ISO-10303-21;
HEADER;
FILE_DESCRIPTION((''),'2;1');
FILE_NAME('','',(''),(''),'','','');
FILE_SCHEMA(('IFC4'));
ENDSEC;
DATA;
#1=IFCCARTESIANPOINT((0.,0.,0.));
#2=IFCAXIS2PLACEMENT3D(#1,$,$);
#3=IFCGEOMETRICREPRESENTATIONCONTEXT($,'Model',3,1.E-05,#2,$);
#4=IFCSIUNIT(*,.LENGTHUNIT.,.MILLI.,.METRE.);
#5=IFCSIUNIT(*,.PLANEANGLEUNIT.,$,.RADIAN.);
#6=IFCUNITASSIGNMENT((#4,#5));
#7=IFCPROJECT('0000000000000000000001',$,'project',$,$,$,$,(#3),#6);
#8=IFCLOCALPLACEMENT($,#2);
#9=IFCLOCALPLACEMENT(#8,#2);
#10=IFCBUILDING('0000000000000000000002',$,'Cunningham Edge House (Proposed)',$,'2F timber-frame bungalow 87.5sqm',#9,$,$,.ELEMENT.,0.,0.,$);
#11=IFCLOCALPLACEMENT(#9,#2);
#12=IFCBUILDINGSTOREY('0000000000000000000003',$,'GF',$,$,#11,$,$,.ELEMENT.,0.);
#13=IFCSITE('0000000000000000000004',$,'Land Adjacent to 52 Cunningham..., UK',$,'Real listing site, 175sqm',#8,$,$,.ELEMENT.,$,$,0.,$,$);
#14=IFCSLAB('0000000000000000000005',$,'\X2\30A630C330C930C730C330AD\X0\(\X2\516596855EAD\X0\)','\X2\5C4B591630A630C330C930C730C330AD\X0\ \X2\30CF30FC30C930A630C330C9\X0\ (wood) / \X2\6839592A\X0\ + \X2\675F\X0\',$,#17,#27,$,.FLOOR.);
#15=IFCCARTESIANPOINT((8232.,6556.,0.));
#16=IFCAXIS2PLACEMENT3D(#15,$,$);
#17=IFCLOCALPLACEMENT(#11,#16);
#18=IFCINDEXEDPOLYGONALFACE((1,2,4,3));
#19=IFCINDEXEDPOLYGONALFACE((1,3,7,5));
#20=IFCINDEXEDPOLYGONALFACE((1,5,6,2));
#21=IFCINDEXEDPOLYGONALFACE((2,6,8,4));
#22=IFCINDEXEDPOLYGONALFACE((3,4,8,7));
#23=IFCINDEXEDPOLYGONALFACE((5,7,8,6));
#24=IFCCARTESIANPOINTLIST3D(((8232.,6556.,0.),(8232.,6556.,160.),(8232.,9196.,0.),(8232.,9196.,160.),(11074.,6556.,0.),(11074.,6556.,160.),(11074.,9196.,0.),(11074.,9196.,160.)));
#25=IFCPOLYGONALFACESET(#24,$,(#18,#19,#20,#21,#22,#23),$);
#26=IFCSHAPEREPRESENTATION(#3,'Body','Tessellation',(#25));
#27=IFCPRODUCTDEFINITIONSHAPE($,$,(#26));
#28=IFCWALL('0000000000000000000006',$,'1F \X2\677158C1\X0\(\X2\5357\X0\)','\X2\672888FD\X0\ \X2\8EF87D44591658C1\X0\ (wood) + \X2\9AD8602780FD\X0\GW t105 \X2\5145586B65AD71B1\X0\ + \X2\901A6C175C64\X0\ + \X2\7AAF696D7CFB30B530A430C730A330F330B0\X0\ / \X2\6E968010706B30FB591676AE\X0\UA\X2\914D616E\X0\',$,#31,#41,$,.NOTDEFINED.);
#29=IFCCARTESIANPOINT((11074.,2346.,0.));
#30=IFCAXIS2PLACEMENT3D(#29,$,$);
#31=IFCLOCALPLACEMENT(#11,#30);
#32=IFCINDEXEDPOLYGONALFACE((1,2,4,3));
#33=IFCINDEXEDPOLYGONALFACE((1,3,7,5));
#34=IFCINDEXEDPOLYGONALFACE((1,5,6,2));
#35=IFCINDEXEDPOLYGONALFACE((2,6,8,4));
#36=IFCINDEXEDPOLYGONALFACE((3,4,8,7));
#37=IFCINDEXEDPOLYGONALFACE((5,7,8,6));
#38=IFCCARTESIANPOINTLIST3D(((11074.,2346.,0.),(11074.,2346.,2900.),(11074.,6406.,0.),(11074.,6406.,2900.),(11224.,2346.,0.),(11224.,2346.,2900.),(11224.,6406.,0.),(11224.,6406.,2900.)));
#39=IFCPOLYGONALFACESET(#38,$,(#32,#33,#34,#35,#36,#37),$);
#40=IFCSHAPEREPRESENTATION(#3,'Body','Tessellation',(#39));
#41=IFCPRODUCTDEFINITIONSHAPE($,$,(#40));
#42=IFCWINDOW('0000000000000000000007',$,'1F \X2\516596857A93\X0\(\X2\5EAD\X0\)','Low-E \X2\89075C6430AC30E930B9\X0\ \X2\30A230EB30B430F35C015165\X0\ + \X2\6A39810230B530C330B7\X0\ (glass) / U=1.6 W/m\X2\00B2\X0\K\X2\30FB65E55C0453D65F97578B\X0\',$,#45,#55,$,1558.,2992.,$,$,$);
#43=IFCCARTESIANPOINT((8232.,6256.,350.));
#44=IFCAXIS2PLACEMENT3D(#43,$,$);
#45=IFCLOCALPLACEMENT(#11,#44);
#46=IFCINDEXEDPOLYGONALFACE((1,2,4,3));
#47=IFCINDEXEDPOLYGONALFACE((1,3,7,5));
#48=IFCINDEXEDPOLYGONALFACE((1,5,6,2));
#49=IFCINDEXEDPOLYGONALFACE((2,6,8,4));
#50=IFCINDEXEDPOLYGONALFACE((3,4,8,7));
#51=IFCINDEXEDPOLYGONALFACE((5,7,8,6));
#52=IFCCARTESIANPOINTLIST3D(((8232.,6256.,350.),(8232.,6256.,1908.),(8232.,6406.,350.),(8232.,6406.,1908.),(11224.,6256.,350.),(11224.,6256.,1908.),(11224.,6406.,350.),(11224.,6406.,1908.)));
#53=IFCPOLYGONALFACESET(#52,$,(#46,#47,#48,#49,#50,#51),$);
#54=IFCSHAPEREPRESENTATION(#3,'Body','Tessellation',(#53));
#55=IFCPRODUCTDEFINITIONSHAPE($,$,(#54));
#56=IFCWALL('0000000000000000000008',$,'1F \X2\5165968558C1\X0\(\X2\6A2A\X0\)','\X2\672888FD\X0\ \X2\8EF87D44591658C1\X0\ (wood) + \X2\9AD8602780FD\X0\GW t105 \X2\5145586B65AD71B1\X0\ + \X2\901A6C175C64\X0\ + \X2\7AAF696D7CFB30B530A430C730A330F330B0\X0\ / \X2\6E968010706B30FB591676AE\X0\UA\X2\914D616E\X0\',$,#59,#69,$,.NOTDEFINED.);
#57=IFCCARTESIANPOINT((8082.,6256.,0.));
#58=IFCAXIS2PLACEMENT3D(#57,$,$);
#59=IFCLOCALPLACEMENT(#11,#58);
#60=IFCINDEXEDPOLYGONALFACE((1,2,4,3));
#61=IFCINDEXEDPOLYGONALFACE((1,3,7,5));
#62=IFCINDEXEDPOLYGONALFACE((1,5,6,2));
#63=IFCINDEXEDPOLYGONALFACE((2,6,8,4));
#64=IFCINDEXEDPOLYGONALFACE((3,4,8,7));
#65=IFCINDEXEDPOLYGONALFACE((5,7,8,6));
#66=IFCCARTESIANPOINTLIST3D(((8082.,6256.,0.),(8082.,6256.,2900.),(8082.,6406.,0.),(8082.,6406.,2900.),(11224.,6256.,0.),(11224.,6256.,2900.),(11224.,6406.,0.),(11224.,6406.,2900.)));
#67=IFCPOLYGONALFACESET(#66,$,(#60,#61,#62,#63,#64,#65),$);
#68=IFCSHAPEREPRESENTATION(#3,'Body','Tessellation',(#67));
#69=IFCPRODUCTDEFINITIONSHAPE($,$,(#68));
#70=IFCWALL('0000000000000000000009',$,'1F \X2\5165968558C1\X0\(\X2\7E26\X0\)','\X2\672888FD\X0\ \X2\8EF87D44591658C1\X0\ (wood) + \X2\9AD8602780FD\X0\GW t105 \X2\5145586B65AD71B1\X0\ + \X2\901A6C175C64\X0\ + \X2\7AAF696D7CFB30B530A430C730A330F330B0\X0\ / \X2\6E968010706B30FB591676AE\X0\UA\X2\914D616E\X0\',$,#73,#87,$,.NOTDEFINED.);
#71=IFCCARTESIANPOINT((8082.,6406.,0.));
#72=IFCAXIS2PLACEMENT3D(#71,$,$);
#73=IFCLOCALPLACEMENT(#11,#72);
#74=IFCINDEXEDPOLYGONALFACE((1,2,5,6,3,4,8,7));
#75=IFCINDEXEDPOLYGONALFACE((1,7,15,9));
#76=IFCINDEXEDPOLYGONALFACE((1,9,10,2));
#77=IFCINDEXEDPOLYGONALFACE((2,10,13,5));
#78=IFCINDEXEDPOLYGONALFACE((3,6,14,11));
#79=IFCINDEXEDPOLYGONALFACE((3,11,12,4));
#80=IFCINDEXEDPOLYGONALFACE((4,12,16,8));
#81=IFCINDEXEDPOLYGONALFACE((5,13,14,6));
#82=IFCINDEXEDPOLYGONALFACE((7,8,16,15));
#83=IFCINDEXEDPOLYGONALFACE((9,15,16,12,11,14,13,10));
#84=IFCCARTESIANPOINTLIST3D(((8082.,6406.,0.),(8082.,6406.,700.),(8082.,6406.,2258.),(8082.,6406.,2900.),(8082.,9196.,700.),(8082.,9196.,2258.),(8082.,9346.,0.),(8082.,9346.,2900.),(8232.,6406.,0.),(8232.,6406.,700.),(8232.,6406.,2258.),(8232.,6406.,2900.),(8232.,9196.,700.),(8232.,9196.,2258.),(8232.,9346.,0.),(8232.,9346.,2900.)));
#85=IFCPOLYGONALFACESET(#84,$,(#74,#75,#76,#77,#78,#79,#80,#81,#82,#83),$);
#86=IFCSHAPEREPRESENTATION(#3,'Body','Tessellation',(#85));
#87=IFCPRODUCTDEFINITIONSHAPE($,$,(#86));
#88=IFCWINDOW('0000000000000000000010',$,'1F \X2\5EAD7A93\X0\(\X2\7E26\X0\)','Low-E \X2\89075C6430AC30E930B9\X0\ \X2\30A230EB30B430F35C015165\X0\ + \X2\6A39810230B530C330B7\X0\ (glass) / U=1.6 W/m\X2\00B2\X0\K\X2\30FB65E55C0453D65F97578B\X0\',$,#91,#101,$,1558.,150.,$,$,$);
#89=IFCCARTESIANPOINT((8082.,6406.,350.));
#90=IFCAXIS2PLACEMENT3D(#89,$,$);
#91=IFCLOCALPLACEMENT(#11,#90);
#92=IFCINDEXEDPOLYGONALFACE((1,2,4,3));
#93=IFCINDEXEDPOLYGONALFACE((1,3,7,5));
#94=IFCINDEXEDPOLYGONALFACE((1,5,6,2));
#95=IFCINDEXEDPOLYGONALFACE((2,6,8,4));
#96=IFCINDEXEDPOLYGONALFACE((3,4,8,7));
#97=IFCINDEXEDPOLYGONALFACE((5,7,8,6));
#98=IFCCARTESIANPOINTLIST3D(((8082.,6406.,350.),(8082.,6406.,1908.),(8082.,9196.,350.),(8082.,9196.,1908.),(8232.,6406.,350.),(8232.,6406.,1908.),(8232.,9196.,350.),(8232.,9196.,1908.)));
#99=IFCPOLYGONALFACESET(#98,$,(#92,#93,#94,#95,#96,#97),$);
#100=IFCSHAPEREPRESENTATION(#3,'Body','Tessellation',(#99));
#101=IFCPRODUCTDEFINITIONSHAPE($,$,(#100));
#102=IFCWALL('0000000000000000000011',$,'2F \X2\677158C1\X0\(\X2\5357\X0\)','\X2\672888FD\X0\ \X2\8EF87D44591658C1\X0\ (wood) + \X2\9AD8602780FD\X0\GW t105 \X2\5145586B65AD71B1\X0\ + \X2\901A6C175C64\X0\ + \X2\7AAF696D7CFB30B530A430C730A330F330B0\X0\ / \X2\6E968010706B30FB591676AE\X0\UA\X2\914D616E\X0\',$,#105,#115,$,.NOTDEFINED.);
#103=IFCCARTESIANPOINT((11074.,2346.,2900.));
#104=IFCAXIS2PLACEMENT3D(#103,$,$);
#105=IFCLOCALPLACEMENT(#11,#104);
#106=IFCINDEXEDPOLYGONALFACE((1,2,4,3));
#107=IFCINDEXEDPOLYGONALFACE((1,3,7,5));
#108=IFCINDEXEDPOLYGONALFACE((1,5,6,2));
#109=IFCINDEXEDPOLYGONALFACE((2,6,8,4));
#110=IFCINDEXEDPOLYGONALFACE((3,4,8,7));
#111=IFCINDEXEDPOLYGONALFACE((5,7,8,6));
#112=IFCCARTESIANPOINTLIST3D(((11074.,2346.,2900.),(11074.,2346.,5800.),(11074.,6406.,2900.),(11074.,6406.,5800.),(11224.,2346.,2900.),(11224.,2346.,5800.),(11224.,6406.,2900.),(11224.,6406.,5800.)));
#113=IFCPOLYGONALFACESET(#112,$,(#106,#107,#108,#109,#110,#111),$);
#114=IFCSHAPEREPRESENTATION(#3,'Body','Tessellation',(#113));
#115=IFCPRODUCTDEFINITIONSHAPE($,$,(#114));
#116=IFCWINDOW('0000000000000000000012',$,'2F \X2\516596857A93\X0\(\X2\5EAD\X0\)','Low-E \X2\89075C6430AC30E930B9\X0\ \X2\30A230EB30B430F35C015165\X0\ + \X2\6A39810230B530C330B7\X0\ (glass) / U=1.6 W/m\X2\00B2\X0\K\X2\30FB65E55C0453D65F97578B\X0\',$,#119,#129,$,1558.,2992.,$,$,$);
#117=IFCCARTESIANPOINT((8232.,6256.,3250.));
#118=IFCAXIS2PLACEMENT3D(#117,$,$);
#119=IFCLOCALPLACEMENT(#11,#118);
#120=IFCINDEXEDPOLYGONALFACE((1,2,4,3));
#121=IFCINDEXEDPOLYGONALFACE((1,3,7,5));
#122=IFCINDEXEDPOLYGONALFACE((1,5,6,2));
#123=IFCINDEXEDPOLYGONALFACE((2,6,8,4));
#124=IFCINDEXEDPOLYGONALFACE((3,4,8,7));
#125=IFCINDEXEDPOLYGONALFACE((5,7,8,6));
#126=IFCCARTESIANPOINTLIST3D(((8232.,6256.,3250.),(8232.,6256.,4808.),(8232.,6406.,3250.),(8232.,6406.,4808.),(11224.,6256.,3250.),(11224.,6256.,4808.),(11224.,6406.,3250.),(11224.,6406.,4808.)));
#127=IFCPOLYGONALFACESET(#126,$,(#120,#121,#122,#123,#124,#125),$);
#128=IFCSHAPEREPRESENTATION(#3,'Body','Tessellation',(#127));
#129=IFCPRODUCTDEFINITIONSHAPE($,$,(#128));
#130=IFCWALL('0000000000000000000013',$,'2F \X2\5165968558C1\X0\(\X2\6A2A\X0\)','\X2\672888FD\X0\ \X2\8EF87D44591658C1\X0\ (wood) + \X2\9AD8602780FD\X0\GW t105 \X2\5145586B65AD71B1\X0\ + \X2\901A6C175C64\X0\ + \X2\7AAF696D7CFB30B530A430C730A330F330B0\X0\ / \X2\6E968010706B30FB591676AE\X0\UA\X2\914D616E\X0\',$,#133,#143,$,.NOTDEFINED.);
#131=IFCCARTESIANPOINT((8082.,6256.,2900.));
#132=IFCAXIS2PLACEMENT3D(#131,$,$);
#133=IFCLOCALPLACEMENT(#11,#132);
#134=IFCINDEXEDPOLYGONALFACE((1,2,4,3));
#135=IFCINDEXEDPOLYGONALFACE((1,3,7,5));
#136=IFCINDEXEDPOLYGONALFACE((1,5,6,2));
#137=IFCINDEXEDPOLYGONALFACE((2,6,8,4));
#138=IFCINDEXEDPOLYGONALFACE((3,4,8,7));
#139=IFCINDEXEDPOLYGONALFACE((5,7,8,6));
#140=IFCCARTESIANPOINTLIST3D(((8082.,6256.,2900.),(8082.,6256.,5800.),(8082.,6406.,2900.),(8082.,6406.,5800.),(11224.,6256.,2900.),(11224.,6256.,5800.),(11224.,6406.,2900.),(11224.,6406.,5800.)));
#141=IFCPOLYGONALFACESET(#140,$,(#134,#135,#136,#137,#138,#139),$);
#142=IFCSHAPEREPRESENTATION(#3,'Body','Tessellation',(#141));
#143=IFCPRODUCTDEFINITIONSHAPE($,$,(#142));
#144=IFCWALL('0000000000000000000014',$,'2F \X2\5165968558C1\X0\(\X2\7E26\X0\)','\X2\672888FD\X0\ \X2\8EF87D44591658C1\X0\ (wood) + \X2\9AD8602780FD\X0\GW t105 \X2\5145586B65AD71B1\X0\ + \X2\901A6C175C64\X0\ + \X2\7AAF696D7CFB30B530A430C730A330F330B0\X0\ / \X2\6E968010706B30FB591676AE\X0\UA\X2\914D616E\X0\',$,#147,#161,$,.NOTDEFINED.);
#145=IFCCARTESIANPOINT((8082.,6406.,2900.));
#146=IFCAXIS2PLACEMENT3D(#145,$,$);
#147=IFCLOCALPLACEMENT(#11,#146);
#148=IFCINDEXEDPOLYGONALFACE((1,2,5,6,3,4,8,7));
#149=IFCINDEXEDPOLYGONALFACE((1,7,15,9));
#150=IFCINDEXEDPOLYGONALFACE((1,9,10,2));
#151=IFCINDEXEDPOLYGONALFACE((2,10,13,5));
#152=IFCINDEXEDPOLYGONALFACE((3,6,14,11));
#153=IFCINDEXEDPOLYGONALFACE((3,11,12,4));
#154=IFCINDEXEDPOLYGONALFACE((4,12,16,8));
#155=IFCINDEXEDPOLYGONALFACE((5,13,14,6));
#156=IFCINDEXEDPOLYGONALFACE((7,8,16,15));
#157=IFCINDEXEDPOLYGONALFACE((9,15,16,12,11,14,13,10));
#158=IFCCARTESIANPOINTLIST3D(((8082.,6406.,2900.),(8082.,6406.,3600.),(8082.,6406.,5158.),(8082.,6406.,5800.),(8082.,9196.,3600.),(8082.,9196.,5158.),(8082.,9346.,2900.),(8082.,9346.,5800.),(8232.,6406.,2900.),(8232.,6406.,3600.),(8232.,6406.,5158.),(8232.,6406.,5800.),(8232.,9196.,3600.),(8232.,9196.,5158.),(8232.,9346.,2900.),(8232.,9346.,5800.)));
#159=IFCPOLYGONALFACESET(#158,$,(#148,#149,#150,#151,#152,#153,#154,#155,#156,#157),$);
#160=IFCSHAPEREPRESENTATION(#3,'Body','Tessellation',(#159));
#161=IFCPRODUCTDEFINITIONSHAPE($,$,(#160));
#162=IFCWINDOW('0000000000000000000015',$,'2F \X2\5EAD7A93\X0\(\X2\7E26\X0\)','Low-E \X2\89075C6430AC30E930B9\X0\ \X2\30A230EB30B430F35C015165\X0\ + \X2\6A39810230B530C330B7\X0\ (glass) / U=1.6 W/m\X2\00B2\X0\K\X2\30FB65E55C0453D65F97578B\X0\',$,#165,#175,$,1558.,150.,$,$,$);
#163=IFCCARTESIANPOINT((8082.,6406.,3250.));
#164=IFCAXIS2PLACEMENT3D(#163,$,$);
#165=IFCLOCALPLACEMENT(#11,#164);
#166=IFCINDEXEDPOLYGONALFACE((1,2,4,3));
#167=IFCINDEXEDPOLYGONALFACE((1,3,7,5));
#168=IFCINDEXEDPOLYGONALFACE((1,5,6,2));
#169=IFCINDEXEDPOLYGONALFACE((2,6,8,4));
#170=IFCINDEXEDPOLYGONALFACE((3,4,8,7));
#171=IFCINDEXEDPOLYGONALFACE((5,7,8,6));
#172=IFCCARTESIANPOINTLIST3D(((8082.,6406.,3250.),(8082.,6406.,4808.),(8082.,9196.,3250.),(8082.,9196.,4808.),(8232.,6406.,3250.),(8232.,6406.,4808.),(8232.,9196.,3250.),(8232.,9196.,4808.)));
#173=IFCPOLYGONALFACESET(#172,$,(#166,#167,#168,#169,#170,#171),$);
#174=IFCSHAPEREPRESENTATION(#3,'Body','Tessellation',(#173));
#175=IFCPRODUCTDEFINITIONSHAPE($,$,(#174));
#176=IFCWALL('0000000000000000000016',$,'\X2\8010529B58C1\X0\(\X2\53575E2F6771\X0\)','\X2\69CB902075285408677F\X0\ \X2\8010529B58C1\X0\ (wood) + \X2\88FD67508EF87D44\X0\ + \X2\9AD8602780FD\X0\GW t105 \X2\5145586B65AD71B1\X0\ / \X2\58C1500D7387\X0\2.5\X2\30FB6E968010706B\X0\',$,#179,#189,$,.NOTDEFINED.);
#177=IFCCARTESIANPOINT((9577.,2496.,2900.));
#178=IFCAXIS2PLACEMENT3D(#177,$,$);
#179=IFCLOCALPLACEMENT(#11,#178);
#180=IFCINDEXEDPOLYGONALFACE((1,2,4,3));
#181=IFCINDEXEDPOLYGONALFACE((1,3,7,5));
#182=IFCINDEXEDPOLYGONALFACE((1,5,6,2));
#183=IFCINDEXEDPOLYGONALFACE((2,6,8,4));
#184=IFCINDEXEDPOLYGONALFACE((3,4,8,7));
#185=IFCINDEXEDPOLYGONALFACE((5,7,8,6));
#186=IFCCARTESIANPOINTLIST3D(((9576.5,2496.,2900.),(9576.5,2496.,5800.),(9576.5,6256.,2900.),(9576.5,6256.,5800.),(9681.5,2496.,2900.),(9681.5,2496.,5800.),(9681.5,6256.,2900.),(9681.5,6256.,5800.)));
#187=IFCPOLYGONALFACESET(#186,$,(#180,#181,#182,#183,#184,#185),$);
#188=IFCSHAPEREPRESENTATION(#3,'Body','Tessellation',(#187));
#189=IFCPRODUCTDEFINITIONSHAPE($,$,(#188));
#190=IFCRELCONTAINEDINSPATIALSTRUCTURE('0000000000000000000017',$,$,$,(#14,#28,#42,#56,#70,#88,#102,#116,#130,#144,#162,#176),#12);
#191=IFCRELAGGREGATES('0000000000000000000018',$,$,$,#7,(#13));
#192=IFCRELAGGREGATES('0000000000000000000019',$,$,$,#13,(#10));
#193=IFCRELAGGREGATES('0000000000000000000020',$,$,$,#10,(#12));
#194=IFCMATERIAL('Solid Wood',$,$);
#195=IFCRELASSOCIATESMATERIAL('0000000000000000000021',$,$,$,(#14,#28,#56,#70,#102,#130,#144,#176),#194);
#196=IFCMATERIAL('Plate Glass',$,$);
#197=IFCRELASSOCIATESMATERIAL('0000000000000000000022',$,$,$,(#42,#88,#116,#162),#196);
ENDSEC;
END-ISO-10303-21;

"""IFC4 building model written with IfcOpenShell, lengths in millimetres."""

from ifc_helpers import new_model, si_unit, frame, frame_2d, origin, place, context, project, spatial, rectangle, extrude, material, element, fill, save


model = new_model("IFC4")

# Units and contexts
model_context = context("Model", 3, precision=1e-05, world=origin())
ifc_project = project(units=[si_unit("LENGTHUNIT", "METRE", prefix="MILLI"), si_unit("PLANEANGLEUNIT", "RADIAN")], contexts=[model_context])

# Site, building, storey
site_placement = place(None, origin())
site = spatial("IfcSite", under=ifc_project, at=site_placement, Name="Land Adjacent to 52 Cunningham..., UK", ObjectType="Real listing site, 175sqm", CompositionType="ELEMENT", RefElevation=0.0)
building_placement = place(site_placement, origin())
building = spatial("IfcBuilding", under=site, at=building_placement, Name="Cunningham Edge House (Proposed)", ObjectType="2F timber-frame bungalow 87.5sqm", CompositionType="ELEMENT", ElevationOfRefHeight=0.0, ElevationOfTerrain=0.0)
storey_placement = place(building_placement, origin())
storey = spatial("IfcBuildingStorey", under=building, at=storey_placement, Name="GF", CompositionType="ELEMENT", Elevation=0.0)

# Slab
ifc_material_1 = material(Name="Solid Wood")
slab_placement = place(storey_placement, frame((8232.0, 6556.0, 0.0)))
element("IfcSlab", 1, at=slab_placement, inside=storey, material=ifc_material_1, Name="ウッドデッキ(入隅庭)", Description="屋外ウッドデッキ ハードウッド (wood) / 根太 + 束", PredefinedType="FLOOR", context=model_context, shape_type="SweptSolid", body=[
    extrude(rectangle(XDim=2842.0, YDim=2640.0, at=frame_2d((1421.0, 1320.0))), frame((8232.0, 6556.0, 0.0)), (0.0, 0.0, 1.0), 160.0),
])

# Wall, opening, window
wall_1_placement = place(storey_placement, frame((11074.0, 2346.0, 0.0)))
wall_1 = element("IfcWall", 2, at=wall_1_placement, inside=storey, material=ifc_material_1, Name="1F 東壁(南)", Description="木製 軸組外壁 (wood) + 高性能GW t105 充填断熱 + 通気層 + 窯業系サイディング / 準耐火・外皮UA配慮", PredefinedType="NOTDEFINED", context=model_context, shape_type="SweptSolid", body=[
    extrude(rectangle(XDim=150.0, YDim=4060.0, at=frame_2d((75.0, 2030.0))), frame((11074.0, 2346.0, 0.0)), (0.0, 0.0, 1.0), 2900.0),
])
opening_1_placement = place(storey_placement, frame((8232.0, 6256.0, 350.0)))
opening_1 = element("IfcOpeningElement", 3, at=opening_1_placement, cuts=wall_1, PredefinedType="NOTDEFINED", context=model_context, shape_type="SweptSolid", body=[
    extrude(rectangle(XDim=2992.0, YDim=150.0, at=frame_2d((1496.0, 75.0))), frame((8232.0, 6256.0, 350.0)), (0.0, 0.0, 1.0), 1558.0),
])
ifc_material_2 = material(Name="Plate Glass")
window_1_placement = place(storey_placement, frame((8232.0, 6256.0, 350.0)))
window_1 = element("IfcWindow", 4, at=window_1_placement, inside=storey, material=ifc_material_2, Name="1F 入隅窓(庭)", Description="Low-E 複層ガラス アルゴン封入 + 樹脂サッシ (glass) / U=1.6 W/m²K・日射取得型", OverallHeight=1558.0, OverallWidth=2992.0, context=model_context, shape_type="SweptSolid", body=[
    extrude(rectangle(XDim=2992.0, YDim=150.0, at=frame_2d((1496.0, 75.0))), frame((8232.0, 6256.0, 350.0)), (0.0, 0.0, 1.0), 1558.0),
])
fill(opening_1, window_1)

# Wall
wall_2_placement = place(storey_placement, frame((8082.0, 6256.0, 0.0)))
element("IfcWall", 5, at=wall_2_placement, inside=storey, material=ifc_material_1, Name="1F 入隅壁(横)", Description="木製 軸組外壁 (wood) + 高性能GW t105 充填断熱 + 通気層 + 窯業系サイディング / 準耐火・外皮UA配慮", PredefinedType="NOTDEFINED", context=model_context, shape_type="SweptSolid", body=[
    extrude(rectangle(XDim=3142.0, YDim=150.0, at=frame_2d((1571.0, 75.0))), frame((8082.0, 6256.0, 0.0)), (0.0, 0.0, 1.0), 2900.0),
])

# Wall, opening, window
wall_3_placement = place(storey_placement, frame((8082.0, 6406.0, 0.0)))
wall_3 = element("IfcWall", 6, at=wall_3_placement, inside=storey, material=ifc_material_1, Name="1F 入隅壁(縦)", Description="木製 軸組外壁 (wood) + 高性能GW t105 充填断熱 + 通気層 + 窯業系サイディング / 準耐火・外皮UA配慮", PredefinedType="NOTDEFINED", context=model_context, shape_type="SweptSolid", body=[
    extrude(rectangle(XDim=150.0, YDim=2940.0, at=frame_2d((75.0, 1470.0))), frame((8082.0, 6406.0, 0.0)), (0.0, 0.0, 1.0), 2900.0),
])
opening_2_placement = place(storey_placement, frame((8082.0, 6406.0, 350.0)))
opening_2 = element("IfcOpeningElement", 7, at=opening_2_placement, cuts=wall_3, PredefinedType="NOTDEFINED", context=model_context, shape_type="SweptSolid", body=[
    extrude(rectangle(XDim=150.0, YDim=2790.0, at=frame_2d((75.0, 1395.0))), frame((8082.0, 6406.0, 350.0)), (0.0, 0.0, 1.0), 1558.0),
])
window_2_placement = place(storey_placement, frame((8082.0, 6406.0, 350.0)))
window_2 = element("IfcWindow", 8, at=window_2_placement, inside=storey, material=ifc_material_2, Name="1F 庭窓(縦)", Description="Low-E 複層ガラス アルゴン封入 + 樹脂サッシ (glass) / U=1.6 W/m²K・日射取得型", OverallHeight=1558.0, OverallWidth=150.0, context=model_context, shape_type="SweptSolid", body=[
    extrude(rectangle(XDim=150.0, YDim=2790.0, at=frame_2d((75.0, 1395.0))), frame((8082.0, 6406.0, 350.0)), (0.0, 0.0, 1.0), 1558.0),
])
fill(opening_2, window_2)

# Wall, opening, window
wall_4_placement = place(storey_placement, frame((11074.0, 2346.0, 2900.0)))
wall_4 = element("IfcWall", 9, at=wall_4_placement, inside=storey, material=ifc_material_1, Name="2F 東壁(南)", Description="木製 軸組外壁 (wood) + 高性能GW t105 充填断熱 + 通気層 + 窯業系サイディング / 準耐火・外皮UA配慮", PredefinedType="NOTDEFINED", context=model_context, shape_type="SweptSolid", body=[
    extrude(rectangle(XDim=150.0, YDim=4060.0, at=frame_2d((75.0, 2030.0))), frame((11074.0, 2346.0, 2900.0)), (0.0, 0.0, 1.0), 2900.0),
])
opening_3_placement = place(storey_placement, frame((8232.0, 6256.0, 3250.0)))
opening_3 = element("IfcOpeningElement", 10, at=opening_3_placement, cuts=wall_4, PredefinedType="NOTDEFINED", context=model_context, shape_type="SweptSolid", body=[
    extrude(rectangle(XDim=2992.0, YDim=150.0, at=frame_2d((1496.0, 75.0))), frame((8232.0, 6256.0, 3250.0)), (0.0, 0.0, 1.0), 1558.0),
])
window_3_placement = place(storey_placement, frame((8232.0, 6256.0, 3250.0)))
window_3 = element("IfcWindow", 11, at=window_3_placement, inside=storey, material=ifc_material_2, Name="2F 入隅窓(庭)", Description="Low-E 複層ガラス アルゴン封入 + 樹脂サッシ (glass) / U=1.6 W/m²K・日射取得型", OverallHeight=1558.0, OverallWidth=2992.0, context=model_context, shape_type="SweptSolid", body=[
    extrude(rectangle(XDim=2992.0, YDim=150.0, at=frame_2d((1496.0, 75.0))), frame((8232.0, 6256.0, 3250.0)), (0.0, 0.0, 1.0), 1558.0),
])
fill(opening_3, window_3)

# Wall
wall_5_placement = place(storey_placement, frame((8082.0, 6256.0, 2900.0)))
element("IfcWall", 12, at=wall_5_placement, inside=storey, material=ifc_material_1, Name="2F 入隅壁(横)", Description="木製 軸組外壁 (wood) + 高性能GW t105 充填断熱 + 通気層 + 窯業系サイディング / 準耐火・外皮UA配慮", PredefinedType="NOTDEFINED", context=model_context, shape_type="SweptSolid", body=[
    extrude(rectangle(XDim=3142.0, YDim=150.0, at=frame_2d((1571.0, 75.0))), frame((8082.0, 6256.0, 2900.0)), (0.0, 0.0, 1.0), 2900.0),
])

# Wall, opening, window
wall_6_placement = place(storey_placement, frame((8082.0, 6406.0, 2900.0)))
wall_6 = element("IfcWall", 13, at=wall_6_placement, inside=storey, material=ifc_material_1, Name="2F 入隅壁(縦)", Description="木製 軸組外壁 (wood) + 高性能GW t105 充填断熱 + 通気層 + 窯業系サイディング / 準耐火・外皮UA配慮", PredefinedType="NOTDEFINED", context=model_context, shape_type="SweptSolid", body=[
    extrude(rectangle(XDim=150.0, YDim=2940.0, at=frame_2d((75.0, 1470.0))), frame((8082.0, 6406.0, 2900.0)), (0.0, 0.0, 1.0), 2900.0),
])
opening_4_placement = place(storey_placement, frame((8082.0, 6406.0, 3250.0)))
opening_4 = element("IfcOpeningElement", 14, at=opening_4_placement, cuts=wall_6, PredefinedType="NOTDEFINED", context=model_context, shape_type="SweptSolid", body=[
    extrude(rectangle(XDim=150.0, YDim=2790.0, at=frame_2d((75.0, 1395.0))), frame((8082.0, 6406.0, 3250.0)), (0.0, 0.0, 1.0), 1558.0),
])
window_4_placement = place(storey_placement, frame((8082.0, 6406.0, 3250.0)))
window_4 = element("IfcWindow", 15, at=window_4_placement, inside=storey, material=ifc_material_2, Name="2F 庭窓(縦)", Description="Low-E 複層ガラス アルゴン封入 + 樹脂サッシ (glass) / U=1.6 W/m²K・日射取得型", OverallHeight=1558.0, OverallWidth=150.0, context=model_context, shape_type="SweptSolid", body=[
    extrude(rectangle(XDim=150.0, YDim=2790.0, at=frame_2d((75.0, 1395.0))), frame((8082.0, 6406.0, 3250.0)), (0.0, 0.0, 1.0), 1558.0),
])
fill(opening_4, window_4)

# Wall
wall_7_placement = place(storey_placement, frame((9577.0, 2496.0, 2900.0)))
element("IfcWall", 16, at=wall_7_placement, inside=storey, material=ifc_material_1, Name="耐力壁(南帯東)", Description="構造用合板 耐力壁 (wood) + 製材軸組 + 高性能GW t105 充填断熱 / 壁倍率2.5・準耐火", PredefinedType="NOTDEFINED", context=model_context, shape_type="SweptSolid", body=[
    extrude(rectangle(XDim=105.0, YDim=3760.0, at=frame_2d((52.0, 1880.0))), frame((9577.0, 2496.0, 2900.0)), (0.0, 0.0, 1.0), 2900.0),
])

save(model, "model.ifc")
